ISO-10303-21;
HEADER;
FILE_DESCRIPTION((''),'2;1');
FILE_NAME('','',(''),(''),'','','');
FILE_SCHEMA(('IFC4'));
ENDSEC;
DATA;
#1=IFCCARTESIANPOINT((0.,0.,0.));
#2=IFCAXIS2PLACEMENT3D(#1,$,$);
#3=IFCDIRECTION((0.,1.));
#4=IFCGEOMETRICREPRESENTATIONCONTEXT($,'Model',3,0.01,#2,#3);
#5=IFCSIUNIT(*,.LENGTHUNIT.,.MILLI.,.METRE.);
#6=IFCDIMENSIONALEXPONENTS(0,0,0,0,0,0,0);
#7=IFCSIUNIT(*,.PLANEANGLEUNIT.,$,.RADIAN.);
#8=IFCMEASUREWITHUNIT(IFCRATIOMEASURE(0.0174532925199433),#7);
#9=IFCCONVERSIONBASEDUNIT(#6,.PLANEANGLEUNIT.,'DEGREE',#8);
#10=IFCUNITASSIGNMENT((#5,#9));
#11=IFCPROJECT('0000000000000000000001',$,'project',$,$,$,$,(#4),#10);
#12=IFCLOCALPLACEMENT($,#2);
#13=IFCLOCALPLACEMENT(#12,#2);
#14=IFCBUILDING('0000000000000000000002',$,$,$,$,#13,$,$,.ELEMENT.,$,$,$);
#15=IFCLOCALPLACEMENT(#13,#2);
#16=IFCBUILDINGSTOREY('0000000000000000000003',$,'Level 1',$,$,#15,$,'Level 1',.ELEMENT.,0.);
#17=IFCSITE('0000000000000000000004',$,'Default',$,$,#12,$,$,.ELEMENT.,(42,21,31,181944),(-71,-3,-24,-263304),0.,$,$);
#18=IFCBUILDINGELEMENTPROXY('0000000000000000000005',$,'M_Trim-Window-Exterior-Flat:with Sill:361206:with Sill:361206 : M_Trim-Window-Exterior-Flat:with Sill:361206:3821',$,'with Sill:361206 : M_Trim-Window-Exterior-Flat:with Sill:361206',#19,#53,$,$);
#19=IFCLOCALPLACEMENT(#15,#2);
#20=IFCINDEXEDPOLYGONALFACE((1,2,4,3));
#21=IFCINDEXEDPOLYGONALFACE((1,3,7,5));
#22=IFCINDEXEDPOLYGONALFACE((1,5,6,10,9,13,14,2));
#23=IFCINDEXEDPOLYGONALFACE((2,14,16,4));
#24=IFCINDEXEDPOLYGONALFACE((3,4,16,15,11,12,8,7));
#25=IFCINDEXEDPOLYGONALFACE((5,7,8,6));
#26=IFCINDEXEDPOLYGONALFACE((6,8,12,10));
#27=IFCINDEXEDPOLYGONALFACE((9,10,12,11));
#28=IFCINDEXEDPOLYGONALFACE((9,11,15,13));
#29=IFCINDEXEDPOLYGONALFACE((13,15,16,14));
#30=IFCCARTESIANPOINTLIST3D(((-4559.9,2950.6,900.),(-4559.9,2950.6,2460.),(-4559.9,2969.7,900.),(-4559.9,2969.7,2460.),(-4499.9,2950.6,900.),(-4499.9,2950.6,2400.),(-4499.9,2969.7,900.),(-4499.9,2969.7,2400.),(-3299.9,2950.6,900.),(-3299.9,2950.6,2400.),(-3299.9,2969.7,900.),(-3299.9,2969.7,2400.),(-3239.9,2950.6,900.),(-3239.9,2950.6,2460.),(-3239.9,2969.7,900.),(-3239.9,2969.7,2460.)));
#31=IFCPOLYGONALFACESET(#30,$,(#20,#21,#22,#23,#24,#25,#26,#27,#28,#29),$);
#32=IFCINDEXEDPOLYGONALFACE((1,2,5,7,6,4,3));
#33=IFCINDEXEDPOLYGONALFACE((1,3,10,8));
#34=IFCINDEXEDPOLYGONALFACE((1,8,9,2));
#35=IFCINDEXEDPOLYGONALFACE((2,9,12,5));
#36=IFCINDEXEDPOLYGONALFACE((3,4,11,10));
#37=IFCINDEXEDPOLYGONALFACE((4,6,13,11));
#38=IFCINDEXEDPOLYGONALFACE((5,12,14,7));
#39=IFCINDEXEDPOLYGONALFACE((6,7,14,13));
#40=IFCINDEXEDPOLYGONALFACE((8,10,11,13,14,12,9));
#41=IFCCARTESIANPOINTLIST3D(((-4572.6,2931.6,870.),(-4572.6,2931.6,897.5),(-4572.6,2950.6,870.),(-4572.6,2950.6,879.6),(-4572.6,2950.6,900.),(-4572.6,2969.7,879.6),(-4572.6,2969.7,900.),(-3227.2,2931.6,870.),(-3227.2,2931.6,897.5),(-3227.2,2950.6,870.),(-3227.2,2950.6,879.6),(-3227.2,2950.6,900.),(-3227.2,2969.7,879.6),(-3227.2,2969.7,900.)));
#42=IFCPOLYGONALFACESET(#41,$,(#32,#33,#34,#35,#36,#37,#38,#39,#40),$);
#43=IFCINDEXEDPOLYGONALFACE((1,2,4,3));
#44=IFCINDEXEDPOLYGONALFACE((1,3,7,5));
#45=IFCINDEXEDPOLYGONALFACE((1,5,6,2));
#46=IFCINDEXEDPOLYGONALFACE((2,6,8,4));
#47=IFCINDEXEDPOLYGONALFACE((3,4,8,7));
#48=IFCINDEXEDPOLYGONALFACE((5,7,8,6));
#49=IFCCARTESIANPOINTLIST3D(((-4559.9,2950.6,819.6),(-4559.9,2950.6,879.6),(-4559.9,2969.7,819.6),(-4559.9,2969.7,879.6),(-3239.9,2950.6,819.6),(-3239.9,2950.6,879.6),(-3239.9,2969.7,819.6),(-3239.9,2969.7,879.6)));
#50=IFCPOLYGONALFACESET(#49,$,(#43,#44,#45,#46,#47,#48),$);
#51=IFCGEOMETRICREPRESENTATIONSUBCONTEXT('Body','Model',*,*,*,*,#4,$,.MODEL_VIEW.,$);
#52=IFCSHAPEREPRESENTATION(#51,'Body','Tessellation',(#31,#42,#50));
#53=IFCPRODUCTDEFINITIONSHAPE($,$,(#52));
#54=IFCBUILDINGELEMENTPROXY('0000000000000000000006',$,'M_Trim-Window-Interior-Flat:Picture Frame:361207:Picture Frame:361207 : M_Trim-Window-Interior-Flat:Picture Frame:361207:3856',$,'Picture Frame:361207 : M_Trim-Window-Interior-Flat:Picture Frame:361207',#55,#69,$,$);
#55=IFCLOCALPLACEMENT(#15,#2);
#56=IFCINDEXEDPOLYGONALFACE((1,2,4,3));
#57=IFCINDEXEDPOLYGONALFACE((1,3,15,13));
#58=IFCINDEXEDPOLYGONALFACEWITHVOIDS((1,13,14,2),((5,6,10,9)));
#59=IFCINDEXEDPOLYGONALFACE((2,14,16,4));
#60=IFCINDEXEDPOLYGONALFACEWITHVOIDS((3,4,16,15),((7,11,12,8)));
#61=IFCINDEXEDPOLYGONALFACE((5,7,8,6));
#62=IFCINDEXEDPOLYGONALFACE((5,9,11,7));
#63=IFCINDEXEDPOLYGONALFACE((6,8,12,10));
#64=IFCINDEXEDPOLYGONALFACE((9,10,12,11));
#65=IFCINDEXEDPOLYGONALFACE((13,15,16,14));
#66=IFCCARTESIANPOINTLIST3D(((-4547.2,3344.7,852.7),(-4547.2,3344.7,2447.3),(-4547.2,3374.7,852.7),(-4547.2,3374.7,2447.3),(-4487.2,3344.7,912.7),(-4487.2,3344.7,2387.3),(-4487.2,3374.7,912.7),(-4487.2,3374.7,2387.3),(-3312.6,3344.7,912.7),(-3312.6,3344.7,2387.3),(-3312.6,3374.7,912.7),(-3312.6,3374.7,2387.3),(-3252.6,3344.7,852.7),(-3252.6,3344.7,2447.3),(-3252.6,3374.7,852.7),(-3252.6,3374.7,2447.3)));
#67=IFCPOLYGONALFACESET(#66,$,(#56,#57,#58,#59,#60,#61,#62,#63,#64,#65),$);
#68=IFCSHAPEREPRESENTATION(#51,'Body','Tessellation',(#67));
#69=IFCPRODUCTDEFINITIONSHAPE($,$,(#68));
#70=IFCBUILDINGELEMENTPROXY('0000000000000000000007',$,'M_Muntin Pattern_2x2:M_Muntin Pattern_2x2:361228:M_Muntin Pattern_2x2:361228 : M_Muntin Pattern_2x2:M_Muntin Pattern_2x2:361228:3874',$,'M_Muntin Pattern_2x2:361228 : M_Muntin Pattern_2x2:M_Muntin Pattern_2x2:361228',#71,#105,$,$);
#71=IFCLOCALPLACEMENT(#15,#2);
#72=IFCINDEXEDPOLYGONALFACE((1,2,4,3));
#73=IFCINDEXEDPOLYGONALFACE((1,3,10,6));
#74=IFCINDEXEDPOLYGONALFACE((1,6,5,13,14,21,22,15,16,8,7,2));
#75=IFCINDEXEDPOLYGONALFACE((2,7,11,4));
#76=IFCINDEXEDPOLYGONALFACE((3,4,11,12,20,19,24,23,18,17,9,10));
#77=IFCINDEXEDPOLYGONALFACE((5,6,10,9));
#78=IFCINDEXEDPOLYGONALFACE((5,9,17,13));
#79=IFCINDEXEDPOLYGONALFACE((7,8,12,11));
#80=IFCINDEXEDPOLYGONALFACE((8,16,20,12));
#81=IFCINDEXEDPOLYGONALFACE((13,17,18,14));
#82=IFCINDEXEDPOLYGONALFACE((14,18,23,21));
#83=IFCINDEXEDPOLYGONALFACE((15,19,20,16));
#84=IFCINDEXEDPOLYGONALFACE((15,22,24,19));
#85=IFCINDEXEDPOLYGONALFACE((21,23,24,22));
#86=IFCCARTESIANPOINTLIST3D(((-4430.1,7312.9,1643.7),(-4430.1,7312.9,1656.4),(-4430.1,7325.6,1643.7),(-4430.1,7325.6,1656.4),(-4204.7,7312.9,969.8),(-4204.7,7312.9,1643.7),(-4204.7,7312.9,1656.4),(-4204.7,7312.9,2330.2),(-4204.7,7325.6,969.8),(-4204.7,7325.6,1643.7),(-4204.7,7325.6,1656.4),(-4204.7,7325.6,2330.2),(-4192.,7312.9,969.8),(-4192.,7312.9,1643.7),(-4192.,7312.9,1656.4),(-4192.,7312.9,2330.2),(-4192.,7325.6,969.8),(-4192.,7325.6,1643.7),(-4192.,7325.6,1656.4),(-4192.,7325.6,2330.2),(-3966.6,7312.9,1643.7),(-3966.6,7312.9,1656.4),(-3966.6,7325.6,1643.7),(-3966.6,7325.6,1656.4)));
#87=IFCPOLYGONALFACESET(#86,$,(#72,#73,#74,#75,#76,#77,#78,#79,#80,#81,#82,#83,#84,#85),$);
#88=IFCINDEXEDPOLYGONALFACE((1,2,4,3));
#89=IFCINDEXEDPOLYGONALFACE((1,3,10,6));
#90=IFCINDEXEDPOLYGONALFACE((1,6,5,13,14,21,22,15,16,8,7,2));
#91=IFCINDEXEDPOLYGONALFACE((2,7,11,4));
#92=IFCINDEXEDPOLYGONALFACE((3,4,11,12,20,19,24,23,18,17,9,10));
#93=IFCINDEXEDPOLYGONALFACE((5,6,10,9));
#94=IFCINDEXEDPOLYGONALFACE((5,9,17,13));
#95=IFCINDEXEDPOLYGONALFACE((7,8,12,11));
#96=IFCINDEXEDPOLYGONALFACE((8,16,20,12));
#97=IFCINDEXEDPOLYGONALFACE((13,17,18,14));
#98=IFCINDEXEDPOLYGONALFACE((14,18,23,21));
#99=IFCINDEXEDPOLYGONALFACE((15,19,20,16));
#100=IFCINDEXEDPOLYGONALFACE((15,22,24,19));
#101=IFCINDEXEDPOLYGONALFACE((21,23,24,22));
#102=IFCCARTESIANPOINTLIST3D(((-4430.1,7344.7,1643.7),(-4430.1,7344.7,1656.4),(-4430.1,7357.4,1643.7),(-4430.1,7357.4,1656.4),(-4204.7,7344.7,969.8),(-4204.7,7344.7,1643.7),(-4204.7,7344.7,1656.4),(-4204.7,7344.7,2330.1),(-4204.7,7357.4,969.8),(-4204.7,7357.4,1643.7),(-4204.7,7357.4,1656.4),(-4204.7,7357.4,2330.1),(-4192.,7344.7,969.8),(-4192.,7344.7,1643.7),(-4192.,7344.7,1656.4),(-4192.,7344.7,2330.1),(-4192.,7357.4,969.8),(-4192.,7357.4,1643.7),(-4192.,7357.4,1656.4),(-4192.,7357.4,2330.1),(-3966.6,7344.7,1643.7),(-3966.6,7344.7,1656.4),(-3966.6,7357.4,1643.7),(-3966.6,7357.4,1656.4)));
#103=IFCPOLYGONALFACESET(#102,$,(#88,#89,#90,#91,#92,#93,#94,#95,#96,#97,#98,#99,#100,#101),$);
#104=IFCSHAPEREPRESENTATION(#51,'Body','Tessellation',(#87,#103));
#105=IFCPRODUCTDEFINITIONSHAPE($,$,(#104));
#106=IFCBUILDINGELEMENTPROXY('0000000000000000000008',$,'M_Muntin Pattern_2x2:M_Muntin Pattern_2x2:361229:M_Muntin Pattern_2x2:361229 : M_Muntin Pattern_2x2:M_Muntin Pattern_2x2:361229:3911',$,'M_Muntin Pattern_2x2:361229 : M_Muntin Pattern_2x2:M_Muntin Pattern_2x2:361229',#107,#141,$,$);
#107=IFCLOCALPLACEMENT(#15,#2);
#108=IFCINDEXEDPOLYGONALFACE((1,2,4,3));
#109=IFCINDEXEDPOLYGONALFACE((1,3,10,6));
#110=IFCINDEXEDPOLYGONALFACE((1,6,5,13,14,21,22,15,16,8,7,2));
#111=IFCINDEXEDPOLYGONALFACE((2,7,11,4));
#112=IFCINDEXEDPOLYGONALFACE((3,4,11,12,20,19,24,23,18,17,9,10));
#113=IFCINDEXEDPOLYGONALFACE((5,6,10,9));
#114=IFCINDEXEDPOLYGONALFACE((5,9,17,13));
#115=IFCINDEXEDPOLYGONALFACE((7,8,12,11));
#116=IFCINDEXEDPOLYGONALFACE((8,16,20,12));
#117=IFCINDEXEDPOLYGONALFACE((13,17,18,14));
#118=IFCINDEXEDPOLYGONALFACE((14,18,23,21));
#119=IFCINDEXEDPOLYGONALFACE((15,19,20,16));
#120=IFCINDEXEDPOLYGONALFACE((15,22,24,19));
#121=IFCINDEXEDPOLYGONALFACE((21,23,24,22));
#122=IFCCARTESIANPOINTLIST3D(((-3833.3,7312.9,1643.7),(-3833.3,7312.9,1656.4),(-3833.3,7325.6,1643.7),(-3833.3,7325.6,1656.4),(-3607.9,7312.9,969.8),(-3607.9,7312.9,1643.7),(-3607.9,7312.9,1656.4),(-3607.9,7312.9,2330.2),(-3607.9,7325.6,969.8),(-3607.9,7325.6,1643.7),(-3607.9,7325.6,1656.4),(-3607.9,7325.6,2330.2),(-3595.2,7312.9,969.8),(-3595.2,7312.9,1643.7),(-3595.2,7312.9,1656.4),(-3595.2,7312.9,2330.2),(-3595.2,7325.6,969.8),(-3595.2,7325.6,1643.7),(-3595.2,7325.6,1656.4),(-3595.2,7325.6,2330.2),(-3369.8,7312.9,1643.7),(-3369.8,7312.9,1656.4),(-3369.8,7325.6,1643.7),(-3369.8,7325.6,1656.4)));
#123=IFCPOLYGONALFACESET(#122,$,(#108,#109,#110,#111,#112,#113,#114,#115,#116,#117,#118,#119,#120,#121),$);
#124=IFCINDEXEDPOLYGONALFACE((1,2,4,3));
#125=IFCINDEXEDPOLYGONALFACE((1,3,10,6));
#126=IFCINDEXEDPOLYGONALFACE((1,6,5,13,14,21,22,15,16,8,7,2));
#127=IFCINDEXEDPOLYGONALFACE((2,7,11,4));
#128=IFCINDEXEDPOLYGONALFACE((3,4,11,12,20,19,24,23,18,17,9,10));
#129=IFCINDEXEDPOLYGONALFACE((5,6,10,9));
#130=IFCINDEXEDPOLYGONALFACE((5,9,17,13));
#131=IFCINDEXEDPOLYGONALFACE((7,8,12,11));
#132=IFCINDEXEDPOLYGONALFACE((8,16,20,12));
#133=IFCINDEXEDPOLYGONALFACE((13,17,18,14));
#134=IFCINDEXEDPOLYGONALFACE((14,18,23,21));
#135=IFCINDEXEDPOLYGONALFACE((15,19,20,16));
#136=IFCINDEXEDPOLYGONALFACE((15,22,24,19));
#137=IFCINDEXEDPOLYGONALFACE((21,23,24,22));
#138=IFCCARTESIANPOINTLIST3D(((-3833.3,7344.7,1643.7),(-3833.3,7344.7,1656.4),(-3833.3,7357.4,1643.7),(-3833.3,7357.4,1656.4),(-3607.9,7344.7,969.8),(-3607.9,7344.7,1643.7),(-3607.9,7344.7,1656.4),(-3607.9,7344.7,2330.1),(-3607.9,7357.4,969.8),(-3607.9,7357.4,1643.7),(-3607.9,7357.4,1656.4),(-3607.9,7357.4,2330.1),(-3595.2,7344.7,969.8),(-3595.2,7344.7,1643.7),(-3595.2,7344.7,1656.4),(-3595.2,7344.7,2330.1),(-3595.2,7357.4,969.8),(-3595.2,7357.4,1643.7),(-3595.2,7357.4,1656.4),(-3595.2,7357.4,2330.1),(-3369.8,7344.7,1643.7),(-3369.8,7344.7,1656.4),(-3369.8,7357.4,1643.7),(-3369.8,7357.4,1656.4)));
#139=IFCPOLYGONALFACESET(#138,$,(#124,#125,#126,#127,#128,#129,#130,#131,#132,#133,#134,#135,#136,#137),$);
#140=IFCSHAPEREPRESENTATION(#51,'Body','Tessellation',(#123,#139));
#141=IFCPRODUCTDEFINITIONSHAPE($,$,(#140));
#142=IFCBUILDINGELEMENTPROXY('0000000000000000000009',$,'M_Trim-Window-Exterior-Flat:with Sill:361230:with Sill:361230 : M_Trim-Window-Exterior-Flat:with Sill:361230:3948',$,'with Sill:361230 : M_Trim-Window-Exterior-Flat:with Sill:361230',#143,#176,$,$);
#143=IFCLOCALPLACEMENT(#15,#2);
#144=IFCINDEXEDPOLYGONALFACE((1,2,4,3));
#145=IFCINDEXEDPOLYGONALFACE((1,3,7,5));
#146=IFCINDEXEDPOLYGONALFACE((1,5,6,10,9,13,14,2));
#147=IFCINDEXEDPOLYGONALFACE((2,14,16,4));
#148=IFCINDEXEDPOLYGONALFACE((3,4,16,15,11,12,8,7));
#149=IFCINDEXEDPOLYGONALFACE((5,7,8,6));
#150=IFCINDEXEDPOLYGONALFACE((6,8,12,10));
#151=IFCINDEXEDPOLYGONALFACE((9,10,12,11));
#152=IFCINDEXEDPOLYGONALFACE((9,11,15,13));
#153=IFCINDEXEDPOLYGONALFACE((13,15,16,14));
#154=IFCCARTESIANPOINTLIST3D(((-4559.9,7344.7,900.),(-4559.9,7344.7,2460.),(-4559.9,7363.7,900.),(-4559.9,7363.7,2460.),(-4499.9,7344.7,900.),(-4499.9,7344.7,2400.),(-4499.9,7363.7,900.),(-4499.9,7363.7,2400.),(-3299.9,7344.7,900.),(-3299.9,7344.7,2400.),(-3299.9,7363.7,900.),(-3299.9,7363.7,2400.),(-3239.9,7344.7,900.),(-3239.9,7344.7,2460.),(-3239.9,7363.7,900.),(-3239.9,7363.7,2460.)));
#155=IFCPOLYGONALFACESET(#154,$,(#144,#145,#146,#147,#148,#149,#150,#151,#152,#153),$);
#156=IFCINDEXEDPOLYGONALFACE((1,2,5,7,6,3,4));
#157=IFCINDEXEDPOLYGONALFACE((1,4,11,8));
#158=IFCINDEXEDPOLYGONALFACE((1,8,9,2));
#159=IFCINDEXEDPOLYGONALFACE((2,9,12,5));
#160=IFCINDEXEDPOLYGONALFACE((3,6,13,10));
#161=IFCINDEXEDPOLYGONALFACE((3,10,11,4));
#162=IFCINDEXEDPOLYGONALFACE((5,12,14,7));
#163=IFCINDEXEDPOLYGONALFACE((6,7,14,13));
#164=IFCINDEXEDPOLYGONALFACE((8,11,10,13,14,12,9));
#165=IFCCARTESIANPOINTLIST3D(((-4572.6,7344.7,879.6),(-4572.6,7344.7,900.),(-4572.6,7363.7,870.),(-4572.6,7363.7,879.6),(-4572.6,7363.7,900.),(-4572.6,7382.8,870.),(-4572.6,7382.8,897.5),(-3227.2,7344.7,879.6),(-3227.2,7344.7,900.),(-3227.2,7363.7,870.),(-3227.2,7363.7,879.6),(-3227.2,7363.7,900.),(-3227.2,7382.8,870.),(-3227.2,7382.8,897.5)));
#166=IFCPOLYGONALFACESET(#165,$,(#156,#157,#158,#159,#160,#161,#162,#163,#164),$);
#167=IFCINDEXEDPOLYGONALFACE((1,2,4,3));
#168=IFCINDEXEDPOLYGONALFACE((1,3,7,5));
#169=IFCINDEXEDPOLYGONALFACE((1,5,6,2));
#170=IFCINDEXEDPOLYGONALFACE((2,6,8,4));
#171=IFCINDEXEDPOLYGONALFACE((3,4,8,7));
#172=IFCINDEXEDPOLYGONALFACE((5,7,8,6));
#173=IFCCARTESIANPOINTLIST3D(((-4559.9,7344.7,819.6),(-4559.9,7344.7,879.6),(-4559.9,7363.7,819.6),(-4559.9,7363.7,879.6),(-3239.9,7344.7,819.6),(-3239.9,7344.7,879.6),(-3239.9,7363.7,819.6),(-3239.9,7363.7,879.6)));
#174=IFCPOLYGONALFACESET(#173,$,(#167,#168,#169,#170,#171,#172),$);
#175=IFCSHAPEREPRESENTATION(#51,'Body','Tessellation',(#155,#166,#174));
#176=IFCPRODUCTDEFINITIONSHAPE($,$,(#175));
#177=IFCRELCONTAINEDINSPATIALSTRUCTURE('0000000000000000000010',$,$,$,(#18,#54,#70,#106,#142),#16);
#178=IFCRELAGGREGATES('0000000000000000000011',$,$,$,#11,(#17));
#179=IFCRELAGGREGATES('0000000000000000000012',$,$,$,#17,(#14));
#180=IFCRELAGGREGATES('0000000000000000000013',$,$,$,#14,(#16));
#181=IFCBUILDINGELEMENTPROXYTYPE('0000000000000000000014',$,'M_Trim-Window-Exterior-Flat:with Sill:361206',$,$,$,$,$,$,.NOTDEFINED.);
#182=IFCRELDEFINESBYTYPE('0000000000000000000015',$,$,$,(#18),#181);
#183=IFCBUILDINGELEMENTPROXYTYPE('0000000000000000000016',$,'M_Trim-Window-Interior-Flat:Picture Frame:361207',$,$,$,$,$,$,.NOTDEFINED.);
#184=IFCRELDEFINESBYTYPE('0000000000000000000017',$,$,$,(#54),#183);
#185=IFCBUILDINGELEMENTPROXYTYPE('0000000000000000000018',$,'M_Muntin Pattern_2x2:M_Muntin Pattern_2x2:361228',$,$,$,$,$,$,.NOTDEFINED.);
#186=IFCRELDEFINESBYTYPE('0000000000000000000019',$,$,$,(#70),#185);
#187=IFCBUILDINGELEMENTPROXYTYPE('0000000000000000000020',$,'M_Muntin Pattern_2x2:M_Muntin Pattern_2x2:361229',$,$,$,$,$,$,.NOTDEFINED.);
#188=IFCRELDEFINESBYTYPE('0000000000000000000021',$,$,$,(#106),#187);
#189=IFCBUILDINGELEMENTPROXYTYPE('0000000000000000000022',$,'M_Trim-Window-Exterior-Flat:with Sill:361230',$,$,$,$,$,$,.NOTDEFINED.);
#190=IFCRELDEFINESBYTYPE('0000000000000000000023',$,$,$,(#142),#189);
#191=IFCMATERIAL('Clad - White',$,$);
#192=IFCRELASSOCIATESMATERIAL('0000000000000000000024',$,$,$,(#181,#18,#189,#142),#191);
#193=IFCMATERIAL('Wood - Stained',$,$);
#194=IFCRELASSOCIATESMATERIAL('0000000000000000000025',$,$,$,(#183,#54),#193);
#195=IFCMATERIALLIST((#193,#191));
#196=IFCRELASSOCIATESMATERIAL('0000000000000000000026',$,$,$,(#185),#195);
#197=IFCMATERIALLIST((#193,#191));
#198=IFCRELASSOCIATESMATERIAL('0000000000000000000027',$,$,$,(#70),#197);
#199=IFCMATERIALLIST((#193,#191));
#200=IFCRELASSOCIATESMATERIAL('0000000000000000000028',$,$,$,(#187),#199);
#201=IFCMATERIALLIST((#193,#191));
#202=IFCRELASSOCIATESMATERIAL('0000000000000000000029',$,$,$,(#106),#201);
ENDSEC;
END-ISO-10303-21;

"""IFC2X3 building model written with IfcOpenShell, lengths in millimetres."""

from ifc_helpers import new_model, entity, si_unit, converted_unit, direction, frame, origin, origin_2d_with_axis, place, context, subcontext, project, spatial, polyline, rectangle, outline, extrude, source, transform, mapped, material, material_list, type_object, type_shapes, element, save


model = new_model("IFC2X3")

# Units and contexts
model_context = context("Model", 3, precision=0.01, world=origin(), true_north=direction((0.0, 1.0)))
body_context = subcontext(model_context, "Body", "Model", "MODEL_VIEW")
ifc_project = project(units=[si_unit("LENGTHUNIT", "METRE", prefix="MILLI"), converted_unit("PLANEANGLEUNIT", "DEGREE", entity("IfcRatioMeasure", 0.0174532925199433), si_unit("PLANEANGLEUNIT", "RADIAN"), dimensions=[0, 0, 0, 0, 0, 0, 0])], contexts=[model_context])

# Site, building, storey
site_placement = place(None, origin())
site = spatial("IfcSite", under=ifc_project, at=site_placement, Name="Default", CompositionType="ELEMENT", RefLatitude=(42, 21, 31, 181944), RefLongitude=(-71, -3, -24, -263304), RefElevation=0.0)
building_placement = place(site_placement, origin())
building = spatial("IfcBuilding", under=site, at=building_placement, CompositionType="ELEMENT")
storey_placement = place(building_placement, origin())
storey = spatial("IfcBuildingStorey", under=building, at=storey_placement, Name="Level 1", LongName="Level 1", CompositionType="ELEMENT", Elevation=0.0)

# Building element proxies
ifc_material_1 = material(Name="Wood - Stained")
ifc_material_2 = material(Name="Clad - White")
building_element_proxy_type_1 = type_object("IfcBuildingElementProxyType", Name="M_Trim-Window-Exterior-Flat:with Sill:361206", PredefinedType="NOTDEFINED", material=ifc_material_2)
shared_shape_1 = source(origin(), body_context, "Body", "SweptSolid", [
    extrude(outline(polyline([(-765.0, -660.0), (795.0, -660.0), (795.0, 660.0), (-765.0, 660.0), (-765.0, 600.0), (735.0, 600.0), (735.0, -600.0), (-765.0, -600.0), (-765.0, -660.0)])), frame((-3899.9, 2950.6, 1665.0), z_axis=(0.0, 1.0, 0.0), x_axis=(0.0, 0.0, 1.0)), (0.0, 0.0, 1.0), 19.1),
    extrude(outline(polyline([(-15.2, 0.0), (-15.2, -19.0), (12.3, -19.0), (14.8, 0.0), (14.8, 19.0), (-5.7, 19.0), (-5.7, 0.0), (-15.2, 0.0)])), frame((-4572.6, 2950.6, 885.2), z_axis=(-1.0, 0.0, 0.0), x_axis=(0.0, 0.0, 1.0)), (0.0, 0.0, -1.0), 1345.4),
    extrude(rectangle(XDim=19.1, YDim=1320.0, at=origin_2d_with_axis()), frame((-3899.9, 2960.1, 819.6), z_axis=(0.0, 0.0, 1.0), x_axis=(0.0, 1.0, 0.0)), (0.0, 0.0, 1.0), 60.0),
])
type_shapes(building_element_proxy_type_1, [shared_shape_1])
proxy_1_placement = place(storey_placement, origin())
element("IfcBuildingElementProxy", 1, at=proxy_1_placement, inside=storey, type_object=building_element_proxy_type_1, material=ifc_material_2, Name="M_Trim-Window-Exterior-Flat:with Sill:361206:with Sill:361206 : M_Trim-Window-Exterior-Flat:with Sill:361206:3821", ObjectType="with Sill:361206 : M_Trim-Window-Exterior-Flat:with Sill:361206", context=body_context, shape_type="MappedRepresentation", body=[
    mapped(shared_shape_1, transform((0.0, 0.0, 0.0), scale=1.0)),
])
building_element_proxy_type_2 = type_object("IfcBuildingElementProxyType", Name="M_Trim-Window-Interior-Flat:Picture Frame:361207", PredefinedType="NOTDEFINED", material=ifc_material_1)
shared_shape_2 = source(origin(), body_context, "Body", "SweptSolid", [
    extrude(outline(polyline([(-797.3, -647.3), (797.3, -647.3), (797.3, 647.3), (-797.3, 647.3), (-797.3, -647.3)]), holes=[polyline([(737.3, 587.3), (737.3, -587.3), (-737.3, -587.3), (-737.3, 587.3), (737.3, 587.3)])]), frame((-3899.9, 3344.7, 1650.0), z_axis=(0.0, 1.0, 0.0), x_axis=(0.0, 0.0, -1.0)), (0.0, 0.0, 1.0), 30.0),
])
type_shapes(building_element_proxy_type_2, [shared_shape_2])
proxy_2_placement = place(storey_placement, origin())
element("IfcBuildingElementProxy", 2, at=proxy_2_placement, inside=storey, type_object=building_element_proxy_type_2, material=ifc_material_1, Name="M_Trim-Window-Interior-Flat:Picture Frame:361207:Picture Frame:361207 : M_Trim-Window-Interior-Flat:Picture Frame:361207:3856", ObjectType="Picture Frame:361207 : M_Trim-Window-Interior-Flat:Picture Frame:361207", context=body_context, shape_type="MappedRepresentation", body=[
    mapped(shared_shape_2, transform((0.0, 0.0, 0.0), scale=1.0)),
])
ifc_material_list_1 = material_list([ifc_material_1, ifc_material_2])
ifc_material_list_2 = material_list([ifc_material_1, ifc_material_2])
building_element_proxy_type_3 = type_object("IfcBuildingElementProxyType", Name="M_Muntin Pattern_2x2:M_Muntin Pattern_2x2:361228", PredefinedType="NOTDEFINED", material=ifc_material_list_2)
shared_shape_3 = source(origin(), body_context, "Body", "SweptSolid", [
    extrude(outline(polyline([(-6.4, -680.2), (6.3, -680.2), (6.3, -6.4), (231.7, -6.4), (231.7, 6.3), (6.3, 6.3), (6.3, 680.2), (-6.4, 680.2), (-6.4, 6.3), (-231.7, 6.3), (-231.7, -6.4), (-6.4, -6.4), (-6.4, -680.2)])), frame((-4198.4, 7312.9, 1650.0), z_axis=(0.0, 1.0, 0.0), x_axis=(1.0, 0.0, 0.0)), (0.0, 0.0, 1.0), 12.7),
    extrude(outline(polyline([(-6.4, -680.1), (6.3, -680.1), (6.3, -6.4), (231.7, -6.4), (231.7, 6.3), (6.3, 6.3), (6.3, 680.2), (-6.4, 680.2), (-6.4, 6.3), (-231.7, 6.3), (-231.7, -6.4), (-6.4, -6.4), (-6.4, -680.1)])), frame((-4198.4, 7344.7, 1650.0), z_axis=(0.0, 1.0, 0.0), x_axis=(1.0, 0.0, 0.0)), (0.0, 0.0, 1.0), 12.7),
])
type_shapes(building_element_proxy_type_3, [shared_shape_3])
proxy_3_placement = place(storey_placement, origin())
element("IfcBuildingElementProxy", 3, at=proxy_3_placement, inside=storey, type_object=building_element_proxy_type_3, material=ifc_material_list_1, Name="M_Muntin Pattern_2x2:M_Muntin Pattern_2x2:361228:M_Muntin Pattern_2x2:361228 : M_Muntin Pattern_2x2:M_Muntin Pattern_2x2:361228:3874", ObjectType="M_Muntin Pattern_2x2:361228 : M_Muntin Pattern_2x2:M_Muntin Pattern_2x2:361228", context=body_context, shape_type="MappedRepresentation", body=[
    mapped(shared_shape_3, transform((0.0, 0.0, 0.0), scale=1.0)),
])
ifc_material_list_3 = material_list([ifc_material_1, ifc_material_2])
ifc_material_list_4 = material_list([ifc_material_1, ifc_material_2])
building_element_proxy_type_4 = type_object("IfcBuildingElementProxyType", Name="M_Muntin Pattern_2x2:M_Muntin Pattern_2x2:361229", PredefinedType="NOTDEFINED", material=ifc_material_list_4)
shared_shape_4 = source(origin(), body_context, "Body", "SweptSolid", [
    extrude(outline(polyline([(-680.1, 6.4), (-680.1, -6.3), (-6.4, -6.3), (-6.4, -231.7), (6.3, -231.7), (6.3, -6.3), (680.2, -6.3), (680.2, 6.4), (6.3, 6.4), (6.3, 231.7), (-6.4, 231.7), (-6.4, 6.4), (-680.1, 6.4)])), frame((-3601.5, 7312.9, 1650.0), z_axis=(0.0, -1.0, 0.0), x_axis=(0.0, 0.0, -1.0)), (0.0, 0.0, -1.0), 12.7),
    extrude(outline(polyline([(-680.1, 6.4), (-680.1, -6.3), (-6.4, -6.3), (-6.4, -231.7), (6.3, -231.7), (6.3, -6.3), (680.2, -6.3), (680.2, 6.4), (6.3, 6.4), (6.3, 231.7), (-6.4, 231.7), (-6.4, 6.4), (-680.1, 6.4)])), frame((-3601.5, 7344.7, 1650.0), z_axis=(0.0, -1.0, 0.0), x_axis=(0.0, 0.0, -1.0)), (0.0, 0.0, -1.0), 12.7),
])
type_shapes(building_element_proxy_type_4, [shared_shape_4])
proxy_4_placement = place(storey_placement, origin())
element("IfcBuildingElementProxy", 4, at=proxy_4_placement, inside=storey, type_object=building_element_proxy_type_4, material=ifc_material_list_3, Name="M_Muntin Pattern_2x2:M_Muntin Pattern_2x2:361229:M_Muntin Pattern_2x2:361229 : M_Muntin Pattern_2x2:M_Muntin Pattern_2x2:361229:3911", ObjectType="M_Muntin Pattern_2x2:361229 : M_Muntin Pattern_2x2:M_Muntin Pattern_2x2:361229", context=body_context, shape_type="MappedRepresentation", body=[
    mapped(shared_shape_4, transform((0.0, 0.0, 0.0), scale=1.0)),
])
building_element_proxy_type_5 = type_object("IfcBuildingElementProxyType", Name="M_Trim-Window-Exterior-Flat:with Sill:361230", PredefinedType="NOTDEFINED", material=ifc_material_2)
shared_shape_5 = source(origin(), body_context, "Body", "SweptSolid", [
    extrude(outline(polyline([(-660.0, -765.0), (-600.0, -765.0), (-600.0, 735.0), (600.0, 735.0), (600.0, -765.0), (660.0, -765.0), (660.0, 795.0), (-660.0, 795.0), (-660.0, -765.0)])), frame((-3899.9, 7344.7, 1665.0), z_axis=(0.0, 1.0, 0.0), x_axis=(-1.0, 0.0, 0.0)), (0.0, 0.0, 1.0), 19.1),
    extrude(outline(polyline([(0.0, -15.2), (19.0, -15.2), (19.0, 12.3), (0.0, 14.8), (-19.0, 14.8), (-19.0, -5.7), (0.0, -5.7), (0.0, -15.2)])), frame((-4572.6, 7363.7, 885.2), z_axis=(1.0, 0.0, 0.0), x_axis=(0.0, 1.0, 0.0)), (0.0, 0.0, 1.0), 1345.4),
    extrude(rectangle(XDim=19.1, YDim=1320.0, at=origin_2d_with_axis()), frame((-3899.9, 7354.2, 819.6), z_axis=(0.0, 0.0, 1.0), x_axis=(0.0, -1.0, 0.0)), (0.0, 0.0, 1.0), 60.0),
])
type_shapes(building_element_proxy_type_5, [shared_shape_5])
proxy_5_placement = place(storey_placement, origin())
element("IfcBuildingElementProxy", 5, at=proxy_5_placement, inside=storey, type_object=building_element_proxy_type_5, material=ifc_material_2, Name="M_Trim-Window-Exterior-Flat:with Sill:361230:with Sill:361230 : M_Trim-Window-Exterior-Flat:with Sill:361230:3948", ObjectType="with Sill:361230 : M_Trim-Window-Exterior-Flat:with Sill:361230", context=body_context, shape_type="MappedRepresentation", body=[
    mapped(shared_shape_5, transform((0.0, 0.0, 0.0), scale=1.0)),
])

save(model, "model.ifc")
